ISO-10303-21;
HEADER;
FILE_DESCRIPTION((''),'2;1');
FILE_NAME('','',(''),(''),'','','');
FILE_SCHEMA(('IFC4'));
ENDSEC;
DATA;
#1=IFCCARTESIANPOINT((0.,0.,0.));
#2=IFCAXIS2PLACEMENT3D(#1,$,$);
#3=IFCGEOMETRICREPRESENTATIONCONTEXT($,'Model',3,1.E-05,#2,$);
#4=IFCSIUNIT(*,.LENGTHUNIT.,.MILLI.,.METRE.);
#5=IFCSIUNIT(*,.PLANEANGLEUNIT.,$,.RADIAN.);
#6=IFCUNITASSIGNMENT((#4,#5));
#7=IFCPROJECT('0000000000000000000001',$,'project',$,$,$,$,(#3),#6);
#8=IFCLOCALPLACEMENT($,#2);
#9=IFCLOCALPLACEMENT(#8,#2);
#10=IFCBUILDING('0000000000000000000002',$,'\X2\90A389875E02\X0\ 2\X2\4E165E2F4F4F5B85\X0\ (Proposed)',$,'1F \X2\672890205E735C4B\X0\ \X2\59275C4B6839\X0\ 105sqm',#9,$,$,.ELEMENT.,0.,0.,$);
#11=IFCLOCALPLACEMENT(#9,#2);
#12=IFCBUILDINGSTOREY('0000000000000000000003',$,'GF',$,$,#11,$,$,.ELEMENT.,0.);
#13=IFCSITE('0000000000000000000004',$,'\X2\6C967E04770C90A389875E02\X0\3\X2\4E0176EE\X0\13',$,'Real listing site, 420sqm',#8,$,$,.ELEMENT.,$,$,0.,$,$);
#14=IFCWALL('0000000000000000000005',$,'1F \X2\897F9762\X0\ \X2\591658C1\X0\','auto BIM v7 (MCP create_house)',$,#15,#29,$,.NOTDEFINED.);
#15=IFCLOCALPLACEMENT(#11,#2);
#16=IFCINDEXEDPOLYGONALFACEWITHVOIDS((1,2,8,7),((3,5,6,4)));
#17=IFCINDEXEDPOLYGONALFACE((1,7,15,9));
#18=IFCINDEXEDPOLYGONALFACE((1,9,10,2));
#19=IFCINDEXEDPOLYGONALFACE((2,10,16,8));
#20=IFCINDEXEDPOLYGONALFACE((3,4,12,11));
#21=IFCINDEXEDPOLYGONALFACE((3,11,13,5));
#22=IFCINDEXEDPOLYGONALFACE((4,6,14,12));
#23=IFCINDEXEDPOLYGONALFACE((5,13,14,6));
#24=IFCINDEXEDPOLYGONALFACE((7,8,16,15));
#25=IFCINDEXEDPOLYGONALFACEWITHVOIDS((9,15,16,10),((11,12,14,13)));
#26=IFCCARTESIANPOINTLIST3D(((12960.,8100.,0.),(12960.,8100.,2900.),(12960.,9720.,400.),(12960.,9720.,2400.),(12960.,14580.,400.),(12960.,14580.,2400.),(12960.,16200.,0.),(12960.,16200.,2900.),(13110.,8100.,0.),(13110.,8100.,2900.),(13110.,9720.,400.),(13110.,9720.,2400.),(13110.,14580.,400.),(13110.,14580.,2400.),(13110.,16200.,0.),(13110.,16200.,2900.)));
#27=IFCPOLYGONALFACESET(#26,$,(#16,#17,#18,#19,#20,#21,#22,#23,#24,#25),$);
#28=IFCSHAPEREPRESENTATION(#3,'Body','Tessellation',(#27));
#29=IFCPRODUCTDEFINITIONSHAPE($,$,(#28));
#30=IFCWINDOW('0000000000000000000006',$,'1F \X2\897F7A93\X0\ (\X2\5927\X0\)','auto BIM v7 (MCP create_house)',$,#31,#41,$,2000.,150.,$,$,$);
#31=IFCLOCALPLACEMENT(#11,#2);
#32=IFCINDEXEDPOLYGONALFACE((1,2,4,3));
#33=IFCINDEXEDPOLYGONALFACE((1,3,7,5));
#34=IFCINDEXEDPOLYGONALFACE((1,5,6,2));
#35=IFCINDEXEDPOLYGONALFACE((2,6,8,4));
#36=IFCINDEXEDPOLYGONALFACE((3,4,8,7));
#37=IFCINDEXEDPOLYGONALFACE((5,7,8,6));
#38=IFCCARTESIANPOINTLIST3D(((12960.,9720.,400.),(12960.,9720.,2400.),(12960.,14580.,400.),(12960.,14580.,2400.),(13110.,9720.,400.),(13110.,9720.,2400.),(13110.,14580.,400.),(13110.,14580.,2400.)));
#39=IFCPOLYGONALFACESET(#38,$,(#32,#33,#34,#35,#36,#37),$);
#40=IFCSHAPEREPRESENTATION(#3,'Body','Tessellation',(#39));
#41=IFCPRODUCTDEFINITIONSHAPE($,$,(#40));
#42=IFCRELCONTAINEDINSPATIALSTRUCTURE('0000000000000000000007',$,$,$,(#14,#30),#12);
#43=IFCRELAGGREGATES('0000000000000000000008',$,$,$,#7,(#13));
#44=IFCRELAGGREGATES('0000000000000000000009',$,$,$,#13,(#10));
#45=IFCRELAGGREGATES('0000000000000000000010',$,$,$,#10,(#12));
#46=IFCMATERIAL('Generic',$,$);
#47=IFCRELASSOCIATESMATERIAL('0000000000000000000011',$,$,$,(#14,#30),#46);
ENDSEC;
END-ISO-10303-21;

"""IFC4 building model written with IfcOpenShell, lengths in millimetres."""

from ifc_helpers import new_model, si_unit, frame, frame_2d, origin, place, context, project, spatial, rectangle, extrude, material, element, fill, save


model = new_model("IFC4")

# Units and contexts
model_context = context("Model", 3, precision=1e-05, world=origin())
ifc_project = project(units=[si_unit("LENGTHUNIT", "METRE", prefix="MILLI"), si_unit("PLANEANGLEUNIT", "RADIAN")], contexts=[model_context])

# Site, building, storey
site_placement = place(None, origin())
site = spatial("IfcSite", under=ifc_project, at=site_placement, Name="沖縄県那覇市3丁目13", ObjectType="Real listing site, 420sqm", CompositionType="ELEMENT", RefElevation=0.0)
building_placement = place(site_placement, origin())
building = spatial("IfcBuilding", under=site, at=building_placement, Name="那覇市 2世帯住宅 (Proposed)", ObjectType="1F 木造平屋 大屋根 105sqm", CompositionType="ELEMENT", ElevationOfRefHeight=0.0, ElevationOfTerrain=0.0)
storey_placement = place(building_placement, origin())
storey = spatial("IfcBuildingStorey", under=building, at=storey_placement, Name="GF", CompositionType="ELEMENT", Elevation=0.0)

# Shared definitions
ifc_material = material(Name="Generic")

# Wall, opening, window
wall_1_placement = place(storey_placement, frame((6480.0, 4050.0, 0.0)))
wall_1 = element("IfcWall", 1, at=wall_1_placement, inside=storey, material=ifc_material, Name="1F 西面 外壁", Description="auto BIM v7 (MCP create_house)", PredefinedType="NOTDEFINED", context=model_context, shape_type="SweptSolid", body=[
    extrude(rectangle(XDim=150.0, YDim=8100.0, at=frame_2d((75.0, 4050.0))), frame((6480.0, 4050.0, 0.0)), (0.0, 0.0, 1.0), 2900.0),
])
opening_1_placement = place(storey_placement, frame((6480.0, 4860.0, 200.0)))
opening_1 = element("IfcOpeningElement", 2, at=opening_1_placement, cuts=wall_1, PredefinedType="NOTDEFINED", context=model_context, shape_type="SweptSolid", body=[
    extrude(rectangle(XDim=150.0, YDim=4860.0, at=frame_2d((75.0, 2430.0))), frame((6480.0, 4860.0, 200.0)), (0.0, 0.0, 1.0), 2000.0),
])
window_1_placement = place(storey_placement, frame((6480.0, 4860.0, 200.0)))
window_1 = element("IfcWindow", 3, at=window_1_placement, inside=storey, material=ifc_material, Name="1F 西窓 (大)", Description="auto BIM v7 (MCP create_house)", OverallHeight=2000.0, OverallWidth=150.0, context=model_context, shape_type="SweptSolid", body=[
    extrude(rectangle(XDim=150.0, YDim=4860.0, at=frame_2d((75.0, 2430.0))), frame((6480.0, 4860.0, 200.0)), (0.0, 0.0, 1.0), 2000.0),
])
fill(opening_1, window_1)

save(model, "model.ifc")
